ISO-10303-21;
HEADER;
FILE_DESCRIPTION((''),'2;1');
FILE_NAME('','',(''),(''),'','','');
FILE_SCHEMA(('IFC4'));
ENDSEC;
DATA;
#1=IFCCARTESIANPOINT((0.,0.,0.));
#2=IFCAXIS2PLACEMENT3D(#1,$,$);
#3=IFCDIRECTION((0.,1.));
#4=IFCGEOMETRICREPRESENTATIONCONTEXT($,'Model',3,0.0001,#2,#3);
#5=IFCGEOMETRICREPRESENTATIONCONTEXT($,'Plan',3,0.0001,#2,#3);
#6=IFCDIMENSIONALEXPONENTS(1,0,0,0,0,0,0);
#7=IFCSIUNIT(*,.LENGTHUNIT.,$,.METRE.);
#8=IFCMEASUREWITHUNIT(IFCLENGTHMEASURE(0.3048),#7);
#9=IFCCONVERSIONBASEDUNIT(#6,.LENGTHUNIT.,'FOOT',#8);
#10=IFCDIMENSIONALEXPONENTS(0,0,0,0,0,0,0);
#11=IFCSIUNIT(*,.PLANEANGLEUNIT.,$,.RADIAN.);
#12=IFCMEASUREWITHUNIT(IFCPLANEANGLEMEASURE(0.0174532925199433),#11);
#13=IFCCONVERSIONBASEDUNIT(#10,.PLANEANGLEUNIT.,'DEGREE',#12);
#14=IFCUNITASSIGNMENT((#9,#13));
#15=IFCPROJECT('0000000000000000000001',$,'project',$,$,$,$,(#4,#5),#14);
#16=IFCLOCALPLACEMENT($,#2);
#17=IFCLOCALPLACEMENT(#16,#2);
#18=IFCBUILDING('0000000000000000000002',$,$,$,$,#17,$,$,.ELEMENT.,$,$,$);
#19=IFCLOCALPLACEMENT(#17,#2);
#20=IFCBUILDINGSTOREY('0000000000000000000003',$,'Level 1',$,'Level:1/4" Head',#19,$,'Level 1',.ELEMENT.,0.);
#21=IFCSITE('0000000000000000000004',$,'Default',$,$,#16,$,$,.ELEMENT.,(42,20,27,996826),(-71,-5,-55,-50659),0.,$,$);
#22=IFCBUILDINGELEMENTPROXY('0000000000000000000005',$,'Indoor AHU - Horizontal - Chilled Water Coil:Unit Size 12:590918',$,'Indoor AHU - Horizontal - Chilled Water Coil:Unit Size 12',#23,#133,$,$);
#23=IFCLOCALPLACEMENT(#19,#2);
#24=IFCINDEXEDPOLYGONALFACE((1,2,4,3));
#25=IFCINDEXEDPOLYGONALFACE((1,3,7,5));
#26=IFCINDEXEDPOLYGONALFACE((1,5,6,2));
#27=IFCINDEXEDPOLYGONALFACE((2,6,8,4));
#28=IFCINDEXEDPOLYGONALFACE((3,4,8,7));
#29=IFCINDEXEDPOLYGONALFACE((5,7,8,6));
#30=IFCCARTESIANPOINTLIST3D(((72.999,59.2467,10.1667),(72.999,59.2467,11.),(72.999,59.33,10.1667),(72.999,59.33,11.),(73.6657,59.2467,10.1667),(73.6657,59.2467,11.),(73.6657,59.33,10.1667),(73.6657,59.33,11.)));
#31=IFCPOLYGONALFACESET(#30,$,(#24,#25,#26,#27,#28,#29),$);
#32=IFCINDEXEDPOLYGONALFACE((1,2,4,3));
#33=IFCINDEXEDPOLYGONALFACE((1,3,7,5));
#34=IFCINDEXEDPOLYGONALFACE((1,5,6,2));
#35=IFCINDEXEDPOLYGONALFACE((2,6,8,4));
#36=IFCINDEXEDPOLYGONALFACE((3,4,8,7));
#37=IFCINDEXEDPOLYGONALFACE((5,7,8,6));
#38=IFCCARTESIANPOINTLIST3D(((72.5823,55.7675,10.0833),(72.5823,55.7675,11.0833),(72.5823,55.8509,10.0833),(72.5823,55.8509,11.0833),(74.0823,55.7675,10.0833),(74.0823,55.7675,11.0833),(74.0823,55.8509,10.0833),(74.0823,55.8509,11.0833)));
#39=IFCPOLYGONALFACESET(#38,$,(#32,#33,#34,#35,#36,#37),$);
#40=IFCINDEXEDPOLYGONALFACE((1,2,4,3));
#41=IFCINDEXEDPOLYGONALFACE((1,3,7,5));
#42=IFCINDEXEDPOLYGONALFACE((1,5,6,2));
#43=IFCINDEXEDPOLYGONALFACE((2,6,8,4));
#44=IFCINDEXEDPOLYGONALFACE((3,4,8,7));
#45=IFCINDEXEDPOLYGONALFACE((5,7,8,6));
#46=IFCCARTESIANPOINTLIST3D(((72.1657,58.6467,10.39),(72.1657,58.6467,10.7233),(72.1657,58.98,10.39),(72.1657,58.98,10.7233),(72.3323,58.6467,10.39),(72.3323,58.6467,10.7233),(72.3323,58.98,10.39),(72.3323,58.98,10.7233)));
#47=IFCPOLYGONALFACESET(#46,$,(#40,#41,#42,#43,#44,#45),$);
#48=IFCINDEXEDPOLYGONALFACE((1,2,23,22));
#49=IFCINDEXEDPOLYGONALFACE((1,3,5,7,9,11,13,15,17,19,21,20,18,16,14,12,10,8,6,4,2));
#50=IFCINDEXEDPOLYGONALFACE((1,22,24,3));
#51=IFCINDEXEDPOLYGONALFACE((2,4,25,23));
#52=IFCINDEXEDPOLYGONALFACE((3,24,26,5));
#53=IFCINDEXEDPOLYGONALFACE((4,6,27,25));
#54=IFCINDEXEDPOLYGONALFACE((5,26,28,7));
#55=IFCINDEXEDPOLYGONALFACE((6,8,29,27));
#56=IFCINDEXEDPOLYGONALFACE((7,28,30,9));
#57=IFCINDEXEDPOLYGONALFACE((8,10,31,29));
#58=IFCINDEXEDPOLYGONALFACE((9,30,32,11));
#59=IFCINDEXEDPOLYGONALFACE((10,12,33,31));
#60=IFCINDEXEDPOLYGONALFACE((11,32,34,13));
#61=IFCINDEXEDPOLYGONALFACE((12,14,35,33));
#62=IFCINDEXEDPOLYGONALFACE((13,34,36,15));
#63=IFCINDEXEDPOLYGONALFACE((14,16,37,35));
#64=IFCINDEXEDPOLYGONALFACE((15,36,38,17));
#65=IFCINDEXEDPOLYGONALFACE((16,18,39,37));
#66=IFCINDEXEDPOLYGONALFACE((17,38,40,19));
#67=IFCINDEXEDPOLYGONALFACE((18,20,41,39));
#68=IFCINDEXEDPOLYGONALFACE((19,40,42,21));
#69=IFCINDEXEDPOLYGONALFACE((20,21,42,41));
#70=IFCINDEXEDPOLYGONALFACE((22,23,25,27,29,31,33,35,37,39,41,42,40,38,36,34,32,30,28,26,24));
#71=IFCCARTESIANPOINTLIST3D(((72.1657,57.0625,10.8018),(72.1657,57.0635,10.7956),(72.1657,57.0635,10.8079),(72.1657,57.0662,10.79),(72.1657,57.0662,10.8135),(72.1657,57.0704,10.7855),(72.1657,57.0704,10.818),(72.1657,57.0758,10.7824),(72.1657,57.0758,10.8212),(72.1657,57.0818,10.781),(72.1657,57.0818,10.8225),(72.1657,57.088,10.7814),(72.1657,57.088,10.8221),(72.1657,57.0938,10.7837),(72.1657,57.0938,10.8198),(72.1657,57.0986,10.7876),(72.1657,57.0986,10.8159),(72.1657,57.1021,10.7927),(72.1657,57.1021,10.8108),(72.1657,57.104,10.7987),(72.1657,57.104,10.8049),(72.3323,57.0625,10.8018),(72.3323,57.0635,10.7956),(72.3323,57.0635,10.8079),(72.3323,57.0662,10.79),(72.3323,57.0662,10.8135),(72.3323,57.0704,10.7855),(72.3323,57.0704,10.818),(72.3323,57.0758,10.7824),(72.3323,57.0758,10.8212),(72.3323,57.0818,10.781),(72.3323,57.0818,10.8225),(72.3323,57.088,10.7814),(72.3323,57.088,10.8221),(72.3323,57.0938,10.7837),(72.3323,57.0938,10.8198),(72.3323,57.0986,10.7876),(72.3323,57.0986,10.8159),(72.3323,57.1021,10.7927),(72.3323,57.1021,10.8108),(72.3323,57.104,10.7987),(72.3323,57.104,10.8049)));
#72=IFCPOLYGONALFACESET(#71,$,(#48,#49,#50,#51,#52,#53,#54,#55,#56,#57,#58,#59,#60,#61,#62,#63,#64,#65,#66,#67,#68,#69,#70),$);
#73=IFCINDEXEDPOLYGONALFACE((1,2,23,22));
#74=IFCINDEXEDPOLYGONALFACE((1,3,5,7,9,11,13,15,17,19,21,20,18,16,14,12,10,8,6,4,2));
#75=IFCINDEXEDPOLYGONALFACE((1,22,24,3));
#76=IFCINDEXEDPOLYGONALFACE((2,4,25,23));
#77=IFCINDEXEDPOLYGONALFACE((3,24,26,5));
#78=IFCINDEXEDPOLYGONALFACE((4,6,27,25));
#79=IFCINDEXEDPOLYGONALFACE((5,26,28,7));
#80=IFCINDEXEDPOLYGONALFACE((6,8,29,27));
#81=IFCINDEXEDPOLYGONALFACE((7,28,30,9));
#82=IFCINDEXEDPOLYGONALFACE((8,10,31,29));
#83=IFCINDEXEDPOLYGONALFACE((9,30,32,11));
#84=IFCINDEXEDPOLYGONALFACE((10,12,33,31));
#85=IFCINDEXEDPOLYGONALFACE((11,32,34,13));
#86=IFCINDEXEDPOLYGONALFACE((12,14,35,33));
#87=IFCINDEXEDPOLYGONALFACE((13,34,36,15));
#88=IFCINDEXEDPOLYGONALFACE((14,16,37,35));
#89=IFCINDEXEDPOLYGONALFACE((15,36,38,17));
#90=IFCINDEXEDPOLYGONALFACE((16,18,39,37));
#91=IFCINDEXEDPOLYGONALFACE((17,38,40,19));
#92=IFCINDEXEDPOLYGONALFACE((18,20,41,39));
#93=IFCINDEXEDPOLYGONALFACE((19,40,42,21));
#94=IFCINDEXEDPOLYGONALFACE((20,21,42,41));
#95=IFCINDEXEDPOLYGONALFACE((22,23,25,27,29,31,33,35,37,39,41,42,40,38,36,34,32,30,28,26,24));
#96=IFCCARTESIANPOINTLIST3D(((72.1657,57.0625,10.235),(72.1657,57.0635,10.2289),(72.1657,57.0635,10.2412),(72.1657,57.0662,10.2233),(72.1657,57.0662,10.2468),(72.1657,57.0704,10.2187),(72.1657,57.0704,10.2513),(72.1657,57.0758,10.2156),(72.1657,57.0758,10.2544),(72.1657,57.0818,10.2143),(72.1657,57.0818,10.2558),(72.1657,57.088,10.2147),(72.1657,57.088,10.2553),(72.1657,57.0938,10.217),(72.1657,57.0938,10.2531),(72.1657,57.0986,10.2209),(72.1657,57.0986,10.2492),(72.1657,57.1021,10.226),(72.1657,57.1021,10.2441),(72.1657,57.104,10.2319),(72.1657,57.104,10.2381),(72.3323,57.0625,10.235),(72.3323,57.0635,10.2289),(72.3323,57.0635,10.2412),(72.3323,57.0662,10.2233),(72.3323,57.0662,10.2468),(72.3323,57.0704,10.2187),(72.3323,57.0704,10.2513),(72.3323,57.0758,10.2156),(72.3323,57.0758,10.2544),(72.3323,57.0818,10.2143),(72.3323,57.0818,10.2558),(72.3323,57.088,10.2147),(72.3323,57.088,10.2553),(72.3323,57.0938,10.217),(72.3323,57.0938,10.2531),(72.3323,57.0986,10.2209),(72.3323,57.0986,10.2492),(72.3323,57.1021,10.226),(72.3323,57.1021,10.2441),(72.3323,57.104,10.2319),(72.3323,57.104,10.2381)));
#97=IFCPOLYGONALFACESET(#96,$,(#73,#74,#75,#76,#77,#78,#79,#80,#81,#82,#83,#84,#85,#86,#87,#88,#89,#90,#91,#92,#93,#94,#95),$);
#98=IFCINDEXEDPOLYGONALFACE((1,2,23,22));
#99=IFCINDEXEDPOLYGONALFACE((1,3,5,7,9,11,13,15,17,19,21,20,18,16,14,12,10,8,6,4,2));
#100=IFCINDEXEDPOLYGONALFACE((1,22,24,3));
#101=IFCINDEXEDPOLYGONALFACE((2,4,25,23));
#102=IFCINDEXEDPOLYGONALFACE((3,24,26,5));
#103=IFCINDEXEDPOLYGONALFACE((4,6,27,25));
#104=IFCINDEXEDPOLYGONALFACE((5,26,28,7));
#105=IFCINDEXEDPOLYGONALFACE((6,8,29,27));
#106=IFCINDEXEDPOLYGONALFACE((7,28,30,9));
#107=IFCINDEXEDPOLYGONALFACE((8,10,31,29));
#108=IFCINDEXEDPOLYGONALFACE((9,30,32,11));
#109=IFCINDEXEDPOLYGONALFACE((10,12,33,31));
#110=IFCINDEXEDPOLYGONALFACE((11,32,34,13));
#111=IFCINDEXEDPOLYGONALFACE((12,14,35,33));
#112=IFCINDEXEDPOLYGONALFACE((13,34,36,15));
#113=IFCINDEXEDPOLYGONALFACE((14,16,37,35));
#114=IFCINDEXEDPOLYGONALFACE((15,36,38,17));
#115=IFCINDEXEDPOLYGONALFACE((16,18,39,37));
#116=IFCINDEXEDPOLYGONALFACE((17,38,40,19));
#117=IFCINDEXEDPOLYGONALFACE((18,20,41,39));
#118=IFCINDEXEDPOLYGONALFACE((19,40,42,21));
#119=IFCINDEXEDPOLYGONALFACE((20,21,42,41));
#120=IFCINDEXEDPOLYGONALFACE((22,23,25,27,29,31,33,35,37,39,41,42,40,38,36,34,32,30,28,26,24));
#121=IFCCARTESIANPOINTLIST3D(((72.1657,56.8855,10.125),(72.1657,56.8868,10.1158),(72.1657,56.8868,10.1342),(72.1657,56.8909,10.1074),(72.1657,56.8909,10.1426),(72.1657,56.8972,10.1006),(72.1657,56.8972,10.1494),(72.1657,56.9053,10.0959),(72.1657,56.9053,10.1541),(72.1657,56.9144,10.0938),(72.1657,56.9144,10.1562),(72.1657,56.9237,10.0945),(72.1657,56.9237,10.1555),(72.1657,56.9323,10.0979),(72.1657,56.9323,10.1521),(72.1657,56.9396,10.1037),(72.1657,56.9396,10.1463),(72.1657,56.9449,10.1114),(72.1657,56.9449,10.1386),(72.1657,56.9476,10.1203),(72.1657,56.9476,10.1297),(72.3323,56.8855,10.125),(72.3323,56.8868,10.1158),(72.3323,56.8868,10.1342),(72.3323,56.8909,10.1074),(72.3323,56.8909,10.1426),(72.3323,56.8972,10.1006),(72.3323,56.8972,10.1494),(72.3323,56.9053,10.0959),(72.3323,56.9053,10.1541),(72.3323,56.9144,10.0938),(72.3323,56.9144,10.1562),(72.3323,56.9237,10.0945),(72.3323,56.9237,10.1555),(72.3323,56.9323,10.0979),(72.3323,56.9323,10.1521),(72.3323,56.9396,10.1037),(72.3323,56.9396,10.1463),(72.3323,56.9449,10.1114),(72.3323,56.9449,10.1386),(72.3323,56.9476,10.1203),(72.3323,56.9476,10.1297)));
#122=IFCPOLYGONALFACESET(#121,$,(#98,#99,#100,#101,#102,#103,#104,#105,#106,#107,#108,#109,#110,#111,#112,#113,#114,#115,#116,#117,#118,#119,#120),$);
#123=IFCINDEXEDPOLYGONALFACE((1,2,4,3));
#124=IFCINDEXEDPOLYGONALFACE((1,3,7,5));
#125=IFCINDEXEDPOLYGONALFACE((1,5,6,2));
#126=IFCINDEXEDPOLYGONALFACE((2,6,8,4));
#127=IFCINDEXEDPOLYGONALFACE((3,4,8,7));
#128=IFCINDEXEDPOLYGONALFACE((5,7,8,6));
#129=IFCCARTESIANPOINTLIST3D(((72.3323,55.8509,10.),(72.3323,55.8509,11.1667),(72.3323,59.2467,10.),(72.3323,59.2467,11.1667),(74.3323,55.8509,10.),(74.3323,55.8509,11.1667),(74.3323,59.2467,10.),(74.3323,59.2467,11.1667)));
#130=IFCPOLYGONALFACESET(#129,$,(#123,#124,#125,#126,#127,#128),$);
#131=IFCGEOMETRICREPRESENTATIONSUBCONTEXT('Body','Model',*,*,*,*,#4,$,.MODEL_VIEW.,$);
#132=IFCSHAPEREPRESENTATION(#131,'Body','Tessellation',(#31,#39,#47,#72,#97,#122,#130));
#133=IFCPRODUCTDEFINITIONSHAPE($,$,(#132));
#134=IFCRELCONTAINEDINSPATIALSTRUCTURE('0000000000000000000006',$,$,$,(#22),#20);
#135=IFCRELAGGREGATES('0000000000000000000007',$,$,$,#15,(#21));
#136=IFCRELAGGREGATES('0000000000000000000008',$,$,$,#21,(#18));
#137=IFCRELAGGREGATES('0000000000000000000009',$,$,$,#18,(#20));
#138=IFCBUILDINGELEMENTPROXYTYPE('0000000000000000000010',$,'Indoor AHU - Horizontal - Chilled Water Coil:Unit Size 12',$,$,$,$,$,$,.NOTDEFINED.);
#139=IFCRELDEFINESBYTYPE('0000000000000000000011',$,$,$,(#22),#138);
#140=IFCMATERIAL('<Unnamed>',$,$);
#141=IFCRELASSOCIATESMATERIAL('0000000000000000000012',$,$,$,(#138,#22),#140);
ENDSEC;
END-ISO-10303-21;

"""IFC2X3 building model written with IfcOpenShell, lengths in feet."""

from ifc_helpers import new_model, entity, si_unit, converted_unit, direction, frame, frame_2d, origin, origin_2d_with_axis, place, context, subcontext, project, spatial, rectangle, circle, extrude, source, transform, mapped, material, type_object, type_shapes, element, save


model = new_model("IFC2X3")

# Units and contexts
model_context = context("Model", 3, precision=0.0001, world=origin(), true_north=direction((0.0, 1.0)))
plan_context = context("Plan", 3, precision=0.0001, world=origin(), true_north=direction((0.0, 1.0)))
body_context = subcontext(model_context, "Body", "Model", "MODEL_VIEW")
ifc_project = project(units=[converted_unit("LENGTHUNIT", "FOOT", entity("IfcLengthMeasure", 0.3048), si_unit("LENGTHUNIT", "METRE"), dimensions=[1, 0, 0, 0, 0, 0, 0]), converted_unit("PLANEANGLEUNIT", "DEGREE", entity("IfcPlaneAngleMeasure", 0.0174532925199433), si_unit("PLANEANGLEUNIT", "RADIAN"), dimensions=[0, 0, 0, 0, 0, 0, 0])], contexts=[model_context, plan_context])

# Site, building, storey
site_placement = place(None, origin())
site = spatial("IfcSite", under=ifc_project, at=site_placement, Name="Default", CompositionType="ELEMENT", RefLatitude=(42, 20, 27, 996826), RefLongitude=(-71, -5, -55, -50659), RefElevation=0.0)
building_placement = place(site_placement, origin())
building = spatial("IfcBuilding", under=site, at=building_placement, CompositionType="ELEMENT")
storey_placement = place(building_placement, origin())
storey = spatial("IfcBuildingStorey", under=building, at=storey_placement, Name="Level 1", ObjectType="Level:1/4\" Head", LongName="Level 1", CompositionType="ELEMENT", Elevation=0.0)

# Shared definitions
ifc_material_1 = material(Name="<Unnamed>")

# Building element proxy
building_element_proxy_type = type_object("IfcBuildingElementProxyType", Name="Indoor AHU - Horizontal - Chilled Water Coil:Unit Size 12", PredefinedType="NOTDEFINED", material=ifc_material_1)
shared_shape_1 = source(origin(), body_context, "Body", "SweptSolid", [
    extrude(rectangle(XDim=0.0833, YDim=0.6667, at=origin_2d_with_axis()), frame((-0.0417, 1.0, 0.1667), z_axis=(0.0, 0.0, 1.0), x_axis=(-1.0, 0.0, 0.0)), (0.0, 0.0, 1.0), 0.8333),
    extrude(rectangle(XDim=0.0833, YDim=1.5, at=origin_2d_with_axis()), frame((3.4375, 1.0, 0.0833), z_axis=(0.0, 0.0, 1.0), x_axis=(-1.0, 0.0, 0.0)), (0.0, 0.0, 1.0), 1.0),
    extrude(rectangle(XDim=0.1667, YDim=0.3333, at=frame_2d((0.0, 0.0), x_axis=(1.0, 0.0))), frame((0.4333, -0.0833, 0.39), z_axis=(0.0, 0.0, 1.0), x_axis=(0.0, 1.0, 0.0)), (0.0, 0.0, 1.0), 0.3333),
    extrude(circle(Radius=0.0208, at=frame_2d((0.0, 0.0), x_axis=(1.0, 0.0))), frame((2.1633, -0.1667, 0.8018), z_axis=(0.0, 1.0, 0.0), x_axis=(1.0, 0.0, 0.0)), (0.0, 0.0, 1.0), 0.1667),
    extrude(circle(Radius=0.0208, at=frame_2d((0.0, 0.0), x_axis=(1.0, 0.0))), frame((2.1633, -0.1667, 0.235), z_axis=(0.0, 1.0, 0.0), x_axis=(1.0, 0.0, 0.0)), (0.0, 0.0, 1.0), 0.1667),
    extrude(circle(Radius=0.0312, at=frame_2d((0.0, 0.0), x_axis=(1.0, 0.0))), frame((2.33, -0.1667, 0.125), z_axis=(0.0, 1.0, 0.0), x_axis=(1.0, 0.0, 0.0)), (0.0, 0.0, 1.0), 0.1667),
    extrude(rectangle(XDim=3.3958, YDim=2.0, at=origin_2d_with_axis()), frame((1.6979, 1.0, 0.0), z_axis=(0.0, 0.0, 1.0), x_axis=(-1.0, 0.0, 0.0)), (0.0, 0.0, 1.0), 1.1667),
])
type_shapes(building_element_proxy_type, [shared_shape_1])
proxy_placement = place(storey_placement, frame((72.3323, 59.2467, 10.0), z_axis=(0.0, 0.0, 1.0), x_axis=(0.0, -1.0, 0.0)))
element("IfcBuildingElementProxy", 1, at=proxy_placement, inside=storey, type_object=building_element_proxy_type, material=ifc_material_1, Name="Indoor AHU - Horizontal - Chilled Water Coil:Unit Size 12:590918", ObjectType="Indoor AHU - Horizontal - Chilled Water Coil:Unit Size 12", context=body_context, shape_type="MappedRepresentation", body=[
    mapped(shared_shape_1, transform((0.0, 0.0, 0.0), scale=1.0)),
])

save(model, "model.ifc")
